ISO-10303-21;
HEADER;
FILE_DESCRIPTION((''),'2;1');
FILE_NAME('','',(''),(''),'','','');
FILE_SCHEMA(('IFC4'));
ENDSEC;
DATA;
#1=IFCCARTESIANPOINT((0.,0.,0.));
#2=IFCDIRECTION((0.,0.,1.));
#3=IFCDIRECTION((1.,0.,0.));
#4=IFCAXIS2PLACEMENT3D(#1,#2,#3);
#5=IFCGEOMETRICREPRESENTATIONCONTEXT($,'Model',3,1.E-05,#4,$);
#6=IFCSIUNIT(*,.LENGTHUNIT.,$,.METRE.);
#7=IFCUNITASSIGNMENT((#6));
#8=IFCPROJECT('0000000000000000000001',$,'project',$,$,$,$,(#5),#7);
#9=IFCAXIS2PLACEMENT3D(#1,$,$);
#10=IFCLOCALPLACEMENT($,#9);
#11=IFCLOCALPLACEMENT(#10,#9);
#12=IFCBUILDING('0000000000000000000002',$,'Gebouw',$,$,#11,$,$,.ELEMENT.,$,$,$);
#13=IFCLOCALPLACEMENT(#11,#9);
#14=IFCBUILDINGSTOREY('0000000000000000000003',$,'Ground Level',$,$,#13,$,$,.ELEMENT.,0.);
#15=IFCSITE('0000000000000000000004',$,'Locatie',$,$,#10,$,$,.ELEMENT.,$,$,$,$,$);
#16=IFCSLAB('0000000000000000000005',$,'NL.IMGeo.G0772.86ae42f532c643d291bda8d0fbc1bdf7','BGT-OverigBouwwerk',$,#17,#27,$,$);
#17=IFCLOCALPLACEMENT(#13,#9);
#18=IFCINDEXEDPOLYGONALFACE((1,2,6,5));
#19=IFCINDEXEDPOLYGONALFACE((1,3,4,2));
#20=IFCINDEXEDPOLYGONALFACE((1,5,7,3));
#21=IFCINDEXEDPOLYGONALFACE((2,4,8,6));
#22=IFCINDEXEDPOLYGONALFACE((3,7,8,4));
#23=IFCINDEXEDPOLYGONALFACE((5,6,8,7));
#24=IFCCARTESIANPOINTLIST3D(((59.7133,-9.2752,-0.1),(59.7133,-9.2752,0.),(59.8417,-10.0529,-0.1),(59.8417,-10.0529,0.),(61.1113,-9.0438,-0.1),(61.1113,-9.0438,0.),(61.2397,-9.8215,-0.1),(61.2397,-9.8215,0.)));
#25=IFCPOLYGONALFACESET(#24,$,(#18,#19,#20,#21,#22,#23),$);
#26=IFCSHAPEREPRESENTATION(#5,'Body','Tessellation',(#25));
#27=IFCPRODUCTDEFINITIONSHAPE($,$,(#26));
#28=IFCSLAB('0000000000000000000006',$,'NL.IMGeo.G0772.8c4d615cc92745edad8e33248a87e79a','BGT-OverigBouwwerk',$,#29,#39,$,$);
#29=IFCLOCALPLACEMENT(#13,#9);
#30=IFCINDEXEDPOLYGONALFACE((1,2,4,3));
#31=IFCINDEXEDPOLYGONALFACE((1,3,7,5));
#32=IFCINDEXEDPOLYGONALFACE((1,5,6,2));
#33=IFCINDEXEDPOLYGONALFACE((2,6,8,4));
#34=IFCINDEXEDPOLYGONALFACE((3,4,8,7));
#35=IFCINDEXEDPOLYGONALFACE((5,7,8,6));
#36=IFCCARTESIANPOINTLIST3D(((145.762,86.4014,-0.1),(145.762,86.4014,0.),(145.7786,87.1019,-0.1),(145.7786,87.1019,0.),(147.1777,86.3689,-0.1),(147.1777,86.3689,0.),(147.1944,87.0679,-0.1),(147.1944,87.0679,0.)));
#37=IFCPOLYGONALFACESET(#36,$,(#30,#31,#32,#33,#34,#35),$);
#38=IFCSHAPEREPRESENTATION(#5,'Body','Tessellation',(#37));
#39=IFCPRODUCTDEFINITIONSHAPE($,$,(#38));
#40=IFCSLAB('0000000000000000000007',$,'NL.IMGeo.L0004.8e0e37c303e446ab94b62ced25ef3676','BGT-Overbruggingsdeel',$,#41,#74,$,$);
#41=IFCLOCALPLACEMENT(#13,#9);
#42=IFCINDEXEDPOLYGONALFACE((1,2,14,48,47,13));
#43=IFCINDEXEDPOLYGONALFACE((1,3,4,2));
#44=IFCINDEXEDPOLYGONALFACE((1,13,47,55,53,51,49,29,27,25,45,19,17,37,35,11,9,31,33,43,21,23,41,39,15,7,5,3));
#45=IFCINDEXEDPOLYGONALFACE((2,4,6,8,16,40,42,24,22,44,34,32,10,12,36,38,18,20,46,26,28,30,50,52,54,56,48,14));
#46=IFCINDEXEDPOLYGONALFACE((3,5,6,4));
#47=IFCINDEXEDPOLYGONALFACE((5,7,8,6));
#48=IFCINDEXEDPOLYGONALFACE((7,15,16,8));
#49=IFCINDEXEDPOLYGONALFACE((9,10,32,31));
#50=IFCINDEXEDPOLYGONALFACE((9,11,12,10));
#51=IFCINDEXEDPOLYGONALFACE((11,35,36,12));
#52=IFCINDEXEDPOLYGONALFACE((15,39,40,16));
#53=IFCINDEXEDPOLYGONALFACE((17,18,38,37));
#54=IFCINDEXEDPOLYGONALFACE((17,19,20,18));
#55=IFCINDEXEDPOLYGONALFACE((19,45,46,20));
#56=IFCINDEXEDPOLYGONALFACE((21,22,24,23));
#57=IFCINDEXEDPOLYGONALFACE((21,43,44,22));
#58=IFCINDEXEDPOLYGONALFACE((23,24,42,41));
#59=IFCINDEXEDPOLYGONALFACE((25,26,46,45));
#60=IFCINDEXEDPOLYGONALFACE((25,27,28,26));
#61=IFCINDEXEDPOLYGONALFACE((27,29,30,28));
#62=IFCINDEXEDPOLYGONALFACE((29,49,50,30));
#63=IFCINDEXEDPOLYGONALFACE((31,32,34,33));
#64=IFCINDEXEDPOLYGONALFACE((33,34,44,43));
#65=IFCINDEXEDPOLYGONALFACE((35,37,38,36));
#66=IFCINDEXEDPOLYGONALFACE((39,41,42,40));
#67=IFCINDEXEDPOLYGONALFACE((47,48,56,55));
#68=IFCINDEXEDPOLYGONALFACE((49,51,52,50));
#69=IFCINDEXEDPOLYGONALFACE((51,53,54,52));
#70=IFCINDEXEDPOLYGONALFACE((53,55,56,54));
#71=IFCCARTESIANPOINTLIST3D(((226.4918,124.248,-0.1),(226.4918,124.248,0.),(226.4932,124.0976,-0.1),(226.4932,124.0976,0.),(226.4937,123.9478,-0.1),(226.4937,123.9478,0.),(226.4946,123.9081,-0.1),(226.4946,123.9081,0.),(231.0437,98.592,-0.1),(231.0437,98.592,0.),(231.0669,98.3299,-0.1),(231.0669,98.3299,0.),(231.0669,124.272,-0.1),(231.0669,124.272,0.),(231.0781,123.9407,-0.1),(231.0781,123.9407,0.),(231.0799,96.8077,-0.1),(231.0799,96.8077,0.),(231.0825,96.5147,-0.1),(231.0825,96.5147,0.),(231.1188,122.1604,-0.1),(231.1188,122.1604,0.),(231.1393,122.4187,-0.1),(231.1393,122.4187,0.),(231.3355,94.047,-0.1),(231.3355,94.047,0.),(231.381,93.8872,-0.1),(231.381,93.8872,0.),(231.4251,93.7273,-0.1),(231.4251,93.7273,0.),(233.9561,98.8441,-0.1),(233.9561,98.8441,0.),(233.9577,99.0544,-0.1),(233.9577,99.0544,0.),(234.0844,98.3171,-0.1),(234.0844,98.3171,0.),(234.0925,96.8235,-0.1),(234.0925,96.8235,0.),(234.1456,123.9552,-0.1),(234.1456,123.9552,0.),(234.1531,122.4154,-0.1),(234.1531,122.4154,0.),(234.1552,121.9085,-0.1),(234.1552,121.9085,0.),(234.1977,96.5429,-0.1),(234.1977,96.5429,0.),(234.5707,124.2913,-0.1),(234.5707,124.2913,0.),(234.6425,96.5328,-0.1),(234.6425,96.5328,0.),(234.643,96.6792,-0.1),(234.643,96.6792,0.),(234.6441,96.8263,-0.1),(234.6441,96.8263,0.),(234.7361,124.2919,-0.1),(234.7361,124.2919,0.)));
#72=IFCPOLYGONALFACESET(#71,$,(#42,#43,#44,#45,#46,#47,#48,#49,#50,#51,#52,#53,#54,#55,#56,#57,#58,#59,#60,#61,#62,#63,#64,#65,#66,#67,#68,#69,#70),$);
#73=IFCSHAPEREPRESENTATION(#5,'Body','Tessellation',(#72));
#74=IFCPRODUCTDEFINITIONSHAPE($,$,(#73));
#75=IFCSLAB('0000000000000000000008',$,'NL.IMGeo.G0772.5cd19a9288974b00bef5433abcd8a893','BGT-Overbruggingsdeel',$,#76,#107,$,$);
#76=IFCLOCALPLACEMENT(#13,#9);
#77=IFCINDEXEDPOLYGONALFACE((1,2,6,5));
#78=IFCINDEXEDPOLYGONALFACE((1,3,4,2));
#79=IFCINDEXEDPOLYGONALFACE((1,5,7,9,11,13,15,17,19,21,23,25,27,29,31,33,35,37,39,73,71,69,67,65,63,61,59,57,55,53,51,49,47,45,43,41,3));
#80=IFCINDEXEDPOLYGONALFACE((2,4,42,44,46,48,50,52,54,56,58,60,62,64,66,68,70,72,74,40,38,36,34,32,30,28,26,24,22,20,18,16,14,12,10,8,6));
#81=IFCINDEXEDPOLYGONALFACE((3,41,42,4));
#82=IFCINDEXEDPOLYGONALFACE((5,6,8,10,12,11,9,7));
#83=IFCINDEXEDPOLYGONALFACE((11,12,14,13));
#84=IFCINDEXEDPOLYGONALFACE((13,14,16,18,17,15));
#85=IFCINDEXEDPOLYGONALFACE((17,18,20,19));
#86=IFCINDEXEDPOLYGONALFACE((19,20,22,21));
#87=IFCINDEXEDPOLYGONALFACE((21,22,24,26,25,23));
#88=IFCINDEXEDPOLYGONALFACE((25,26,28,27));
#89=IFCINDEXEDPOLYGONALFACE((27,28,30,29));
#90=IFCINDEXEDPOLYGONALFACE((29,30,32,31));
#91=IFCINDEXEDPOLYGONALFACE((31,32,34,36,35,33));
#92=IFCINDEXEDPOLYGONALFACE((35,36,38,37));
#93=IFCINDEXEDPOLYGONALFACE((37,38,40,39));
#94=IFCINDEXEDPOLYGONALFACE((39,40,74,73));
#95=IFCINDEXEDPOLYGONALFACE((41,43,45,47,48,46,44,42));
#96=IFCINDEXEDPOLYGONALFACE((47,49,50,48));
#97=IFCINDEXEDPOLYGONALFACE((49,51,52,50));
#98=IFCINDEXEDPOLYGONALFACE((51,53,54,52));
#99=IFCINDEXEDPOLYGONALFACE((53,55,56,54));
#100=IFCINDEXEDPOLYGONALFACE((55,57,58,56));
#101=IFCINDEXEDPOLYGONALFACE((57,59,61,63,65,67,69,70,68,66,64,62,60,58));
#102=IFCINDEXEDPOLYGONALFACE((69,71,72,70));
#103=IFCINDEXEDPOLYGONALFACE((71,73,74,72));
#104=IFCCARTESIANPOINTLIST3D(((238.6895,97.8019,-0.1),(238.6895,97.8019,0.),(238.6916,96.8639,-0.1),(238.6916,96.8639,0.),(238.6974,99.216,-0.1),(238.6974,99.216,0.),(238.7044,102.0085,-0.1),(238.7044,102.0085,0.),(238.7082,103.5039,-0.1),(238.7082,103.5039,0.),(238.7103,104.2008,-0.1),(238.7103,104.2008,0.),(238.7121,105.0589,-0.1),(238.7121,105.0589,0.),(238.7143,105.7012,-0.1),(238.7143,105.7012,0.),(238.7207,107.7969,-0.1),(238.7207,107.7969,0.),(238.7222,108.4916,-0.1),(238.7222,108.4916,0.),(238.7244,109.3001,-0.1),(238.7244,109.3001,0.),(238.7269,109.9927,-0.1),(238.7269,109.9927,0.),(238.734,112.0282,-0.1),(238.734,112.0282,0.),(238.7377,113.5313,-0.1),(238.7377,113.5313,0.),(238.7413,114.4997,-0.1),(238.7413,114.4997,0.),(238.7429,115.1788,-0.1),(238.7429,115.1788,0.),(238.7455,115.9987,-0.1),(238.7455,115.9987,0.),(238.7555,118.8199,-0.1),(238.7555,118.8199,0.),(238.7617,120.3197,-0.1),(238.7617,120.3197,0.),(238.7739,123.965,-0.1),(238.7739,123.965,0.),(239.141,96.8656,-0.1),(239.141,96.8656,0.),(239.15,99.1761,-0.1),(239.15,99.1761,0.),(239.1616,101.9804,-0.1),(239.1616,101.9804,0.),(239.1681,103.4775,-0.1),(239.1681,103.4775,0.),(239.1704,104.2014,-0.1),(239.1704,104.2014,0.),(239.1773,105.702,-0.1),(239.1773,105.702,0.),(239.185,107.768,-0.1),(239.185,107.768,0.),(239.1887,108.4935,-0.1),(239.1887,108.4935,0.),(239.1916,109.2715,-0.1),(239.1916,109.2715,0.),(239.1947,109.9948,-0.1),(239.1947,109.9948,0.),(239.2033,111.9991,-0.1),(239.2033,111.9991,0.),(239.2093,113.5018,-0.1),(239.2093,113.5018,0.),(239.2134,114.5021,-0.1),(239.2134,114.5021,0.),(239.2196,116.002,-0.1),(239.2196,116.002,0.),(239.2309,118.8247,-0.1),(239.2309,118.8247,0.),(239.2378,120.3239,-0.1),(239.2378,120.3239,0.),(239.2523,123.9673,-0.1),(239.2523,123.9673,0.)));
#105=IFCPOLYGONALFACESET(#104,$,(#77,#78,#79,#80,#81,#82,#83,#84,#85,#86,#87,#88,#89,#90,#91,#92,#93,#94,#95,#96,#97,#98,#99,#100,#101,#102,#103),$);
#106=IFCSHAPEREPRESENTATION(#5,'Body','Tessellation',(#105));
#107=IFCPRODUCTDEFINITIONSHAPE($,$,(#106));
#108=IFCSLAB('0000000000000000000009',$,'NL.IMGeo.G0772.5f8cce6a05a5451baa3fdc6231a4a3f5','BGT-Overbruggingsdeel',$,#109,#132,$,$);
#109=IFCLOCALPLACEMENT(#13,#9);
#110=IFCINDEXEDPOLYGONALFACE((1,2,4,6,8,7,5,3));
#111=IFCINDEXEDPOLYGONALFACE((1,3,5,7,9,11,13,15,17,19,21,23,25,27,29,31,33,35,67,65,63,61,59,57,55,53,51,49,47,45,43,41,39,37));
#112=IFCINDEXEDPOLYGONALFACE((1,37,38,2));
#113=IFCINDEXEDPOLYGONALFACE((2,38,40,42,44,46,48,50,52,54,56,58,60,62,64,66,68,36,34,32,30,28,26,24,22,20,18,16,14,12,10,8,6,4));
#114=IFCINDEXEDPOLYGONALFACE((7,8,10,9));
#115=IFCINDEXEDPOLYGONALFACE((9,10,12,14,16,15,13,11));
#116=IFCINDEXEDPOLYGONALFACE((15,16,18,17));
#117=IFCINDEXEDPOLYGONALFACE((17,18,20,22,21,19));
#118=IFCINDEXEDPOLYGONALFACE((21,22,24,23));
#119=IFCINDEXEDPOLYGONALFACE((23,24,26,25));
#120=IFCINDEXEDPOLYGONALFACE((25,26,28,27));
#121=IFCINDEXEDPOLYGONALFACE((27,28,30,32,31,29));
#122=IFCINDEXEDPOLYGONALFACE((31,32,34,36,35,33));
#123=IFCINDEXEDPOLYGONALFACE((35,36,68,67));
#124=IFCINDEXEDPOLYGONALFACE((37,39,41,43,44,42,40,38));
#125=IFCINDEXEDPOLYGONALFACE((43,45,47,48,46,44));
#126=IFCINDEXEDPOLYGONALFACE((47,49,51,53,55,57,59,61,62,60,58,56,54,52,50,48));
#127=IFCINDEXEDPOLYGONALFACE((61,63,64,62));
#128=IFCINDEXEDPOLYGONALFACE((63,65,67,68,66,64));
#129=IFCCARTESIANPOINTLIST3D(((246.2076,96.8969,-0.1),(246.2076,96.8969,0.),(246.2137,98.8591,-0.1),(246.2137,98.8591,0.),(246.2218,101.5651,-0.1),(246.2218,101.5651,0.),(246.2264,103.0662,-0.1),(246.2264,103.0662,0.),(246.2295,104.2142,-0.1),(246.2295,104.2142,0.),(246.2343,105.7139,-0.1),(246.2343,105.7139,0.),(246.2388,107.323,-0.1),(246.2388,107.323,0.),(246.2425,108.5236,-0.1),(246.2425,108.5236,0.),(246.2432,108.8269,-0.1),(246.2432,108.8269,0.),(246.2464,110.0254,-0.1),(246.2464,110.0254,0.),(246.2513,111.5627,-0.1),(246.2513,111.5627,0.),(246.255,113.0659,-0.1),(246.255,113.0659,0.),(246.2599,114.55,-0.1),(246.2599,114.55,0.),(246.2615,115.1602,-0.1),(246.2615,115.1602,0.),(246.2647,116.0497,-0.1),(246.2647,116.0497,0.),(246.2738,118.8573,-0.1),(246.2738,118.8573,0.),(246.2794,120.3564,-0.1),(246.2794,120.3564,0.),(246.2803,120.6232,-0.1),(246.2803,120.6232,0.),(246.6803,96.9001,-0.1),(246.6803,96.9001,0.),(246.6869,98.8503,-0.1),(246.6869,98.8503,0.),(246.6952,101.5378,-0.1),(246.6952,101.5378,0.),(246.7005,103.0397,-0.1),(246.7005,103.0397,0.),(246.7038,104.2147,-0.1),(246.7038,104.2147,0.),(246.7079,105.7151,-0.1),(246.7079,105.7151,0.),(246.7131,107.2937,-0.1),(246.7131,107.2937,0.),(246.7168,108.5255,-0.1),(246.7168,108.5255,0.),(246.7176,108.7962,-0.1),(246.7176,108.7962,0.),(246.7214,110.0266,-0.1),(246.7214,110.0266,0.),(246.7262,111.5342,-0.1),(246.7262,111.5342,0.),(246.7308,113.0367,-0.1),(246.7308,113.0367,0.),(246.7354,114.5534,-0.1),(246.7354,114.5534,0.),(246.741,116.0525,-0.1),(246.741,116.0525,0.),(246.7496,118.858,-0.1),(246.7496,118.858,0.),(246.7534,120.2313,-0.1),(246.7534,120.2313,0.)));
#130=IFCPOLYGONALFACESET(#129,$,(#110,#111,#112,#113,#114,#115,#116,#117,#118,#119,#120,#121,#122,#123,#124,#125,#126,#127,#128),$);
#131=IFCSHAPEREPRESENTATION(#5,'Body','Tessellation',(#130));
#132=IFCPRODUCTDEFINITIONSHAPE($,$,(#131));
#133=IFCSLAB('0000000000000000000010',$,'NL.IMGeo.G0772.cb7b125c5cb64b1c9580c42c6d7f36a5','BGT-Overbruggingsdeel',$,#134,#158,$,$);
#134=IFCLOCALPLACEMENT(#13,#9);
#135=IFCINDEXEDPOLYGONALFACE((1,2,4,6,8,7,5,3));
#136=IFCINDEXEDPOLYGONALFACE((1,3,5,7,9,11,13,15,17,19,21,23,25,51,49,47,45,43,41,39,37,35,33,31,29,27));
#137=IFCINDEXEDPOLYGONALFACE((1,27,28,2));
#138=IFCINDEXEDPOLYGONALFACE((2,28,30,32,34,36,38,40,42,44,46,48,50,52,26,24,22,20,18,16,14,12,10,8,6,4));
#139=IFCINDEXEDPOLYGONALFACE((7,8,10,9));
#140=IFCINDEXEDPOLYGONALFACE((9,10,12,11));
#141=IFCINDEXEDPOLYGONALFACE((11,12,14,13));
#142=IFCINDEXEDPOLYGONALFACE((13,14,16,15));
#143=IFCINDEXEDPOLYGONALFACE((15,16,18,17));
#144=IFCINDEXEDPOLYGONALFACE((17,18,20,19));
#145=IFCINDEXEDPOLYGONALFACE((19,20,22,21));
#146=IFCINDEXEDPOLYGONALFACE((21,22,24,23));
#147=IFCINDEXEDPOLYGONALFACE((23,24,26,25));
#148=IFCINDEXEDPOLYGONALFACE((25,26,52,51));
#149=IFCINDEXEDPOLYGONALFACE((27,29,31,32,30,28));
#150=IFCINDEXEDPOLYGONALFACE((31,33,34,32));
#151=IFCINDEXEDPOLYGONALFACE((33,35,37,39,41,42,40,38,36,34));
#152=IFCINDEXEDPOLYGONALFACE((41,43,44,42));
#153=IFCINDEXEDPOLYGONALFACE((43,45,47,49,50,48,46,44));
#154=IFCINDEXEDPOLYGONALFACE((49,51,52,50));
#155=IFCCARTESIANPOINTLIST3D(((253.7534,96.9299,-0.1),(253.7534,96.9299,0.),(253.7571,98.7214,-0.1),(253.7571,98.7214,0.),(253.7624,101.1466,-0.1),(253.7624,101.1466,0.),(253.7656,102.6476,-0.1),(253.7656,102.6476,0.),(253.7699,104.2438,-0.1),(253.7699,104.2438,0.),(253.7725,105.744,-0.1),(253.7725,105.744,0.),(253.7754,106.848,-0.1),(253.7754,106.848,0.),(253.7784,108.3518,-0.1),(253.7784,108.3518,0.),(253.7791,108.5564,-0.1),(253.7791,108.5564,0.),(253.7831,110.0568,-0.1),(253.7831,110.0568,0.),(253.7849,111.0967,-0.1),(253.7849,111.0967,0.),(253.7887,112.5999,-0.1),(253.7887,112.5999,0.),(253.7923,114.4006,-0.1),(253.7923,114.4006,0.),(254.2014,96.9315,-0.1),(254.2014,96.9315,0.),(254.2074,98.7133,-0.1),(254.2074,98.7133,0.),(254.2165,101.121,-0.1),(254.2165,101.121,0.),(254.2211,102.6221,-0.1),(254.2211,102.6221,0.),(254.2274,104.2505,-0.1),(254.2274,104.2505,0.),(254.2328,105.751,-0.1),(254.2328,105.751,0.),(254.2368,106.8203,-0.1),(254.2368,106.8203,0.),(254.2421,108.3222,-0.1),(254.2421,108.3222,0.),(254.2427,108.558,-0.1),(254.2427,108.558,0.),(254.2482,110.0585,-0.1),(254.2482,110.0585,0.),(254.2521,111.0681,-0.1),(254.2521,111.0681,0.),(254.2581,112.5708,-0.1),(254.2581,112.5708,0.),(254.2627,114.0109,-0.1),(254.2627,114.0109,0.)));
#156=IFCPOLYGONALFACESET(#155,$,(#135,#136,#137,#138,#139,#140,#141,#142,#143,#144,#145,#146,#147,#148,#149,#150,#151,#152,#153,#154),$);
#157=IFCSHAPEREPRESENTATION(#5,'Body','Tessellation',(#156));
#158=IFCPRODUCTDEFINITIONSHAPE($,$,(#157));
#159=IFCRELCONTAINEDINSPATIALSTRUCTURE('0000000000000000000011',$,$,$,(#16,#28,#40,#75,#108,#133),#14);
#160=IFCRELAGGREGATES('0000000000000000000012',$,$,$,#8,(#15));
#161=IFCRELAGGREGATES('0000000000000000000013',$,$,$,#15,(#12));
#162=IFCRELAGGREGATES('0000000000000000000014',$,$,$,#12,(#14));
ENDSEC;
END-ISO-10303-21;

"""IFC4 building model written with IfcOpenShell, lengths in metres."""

from ifc_helpers import new_model, si_unit, frame, origin, origin_with_axes, place, context, project, spatial, polyline, outline, extrude, element, save


model = new_model("IFC4")

# Units and contexts
model_context = context("Model", 3, precision=1e-05, world=origin_with_axes())
ifc_project = project(units=[si_unit("LENGTHUNIT", "METRE")], contexts=[model_context])

# Site, building, storey
site_placement = place(None, origin())
site = spatial("IfcSite", under=ifc_project, at=site_placement, Name="Locatie", CompositionType="ELEMENT")
building_placement = place(site_placement, origin())
building = spatial("IfcBuilding", under=site, at=building_placement, Name="Gebouw", CompositionType="ELEMENT")
storey_placement = place(building_placement, origin())
storey = spatial("IfcBuildingStorey", under=building, at=storey_placement, Name="Ground Level", CompositionType="ELEMENT", Elevation=0.0)

# Slabs
slab_1_placement = place(storey_placement, origin())
element("IfcSlab", 1, at=slab_1_placement, inside=storey, Name="NL.IMGeo.G0772.86ae42f532c643d291bda8d0fbc1bdf7", Description="BGT-OverigBouwwerk", context=model_context, shape_type="SweptSolid", body=[
    extrude(outline(polyline([(59.8417, -10.0529), (59.7133, -9.2752), (61.1113, -9.0438), (61.2397, -9.8215), (59.8417, -10.0529)])), frame((0.0, 0.0, -0.1), z_axis=(0.0, 0.0, 1.0), x_axis=(1.0, 0.0, 0.0)), (0.0, 0.0, 1.0), 0.1),
])
slab_2_placement = place(storey_placement, origin())
element("IfcSlab", 2, at=slab_2_placement, inside=storey, Name="NL.IMGeo.G0772.8c4d615cc92745edad8e33248a87e79a", Description="BGT-OverigBouwwerk", context=model_context, shape_type="SweptSolid", body=[
    extrude(outline(polyline([(145.762, 86.4014), (145.7786, 87.1019), (147.1944, 87.0679), (147.1777, 86.3689), (145.762, 86.4014)])), frame((0.0, 0.0, -0.1), z_axis=(0.0, 0.0, 1.0), x_axis=(1.0, 0.0, 0.0)), (0.0, 0.0, 1.0), 0.1),
])
slab_3_placement = place(storey_placement, origin())
element("IfcSlab", 3, at=slab_3_placement, inside=storey, Name="NL.IMGeo.L0004.8e0e37c303e446ab94b62ced25ef3676", Description="BGT-Overbruggingsdeel", context=model_context, shape_type="SweptSolid", body=[
    extrude(outline(polyline([(234.1977, 96.5429), (231.0825, 96.5147), (231.0799, 96.8077), (234.0925, 96.8235), (234.0844, 98.3171), (231.0669, 98.3299), (231.0437, 98.592), (233.9561, 98.8441), (233.9577, 99.0544), (234.1552, 121.9085), (231.1188, 122.1604), (231.1393, 122.4187), (234.1531, 122.4154), (234.1456, 123.9552), (231.0781, 123.9407), (226.4946, 123.9081), (226.4937, 123.9478), (226.4932, 124.0976), (226.4918, 124.248), (231.0669, 124.272), (234.5707, 124.2913), (234.7361, 124.2919), (234.6441, 96.8263), (234.643, 96.6792), (234.6425, 96.5328), (231.4251, 93.7273), (231.381, 93.8872), (231.3355, 94.047), (234.1977, 96.5429)])), frame((0.0, 0.0, -0.1), z_axis=(0.0, 0.0, 1.0), x_axis=(1.0, 0.0, 0.0)), (0.0, 0.0, 1.0), 0.1),
])
slab_4_placement = place(storey_placement, origin())
element("IfcSlab", 4, at=slab_4_placement, inside=storey, Name="NL.IMGeo.G0772.5cd19a9288974b00bef5433abcd8a893", Description="BGT-Overbruggingsdeel", context=model_context, shape_type="SweptSolid", body=[
    extrude(outline(polyline([(239.1773, 105.702), (239.1704, 104.2014), (239.1681, 103.4775), (239.1616, 101.9804), (239.15, 99.1761), (239.141, 96.8656), (238.6916, 96.8639), (238.6895, 97.8019), (238.6974, 99.216), (238.7044, 102.0085), (238.7082, 103.5039), (238.7103, 104.2008), (238.7121, 105.0589), (238.7143, 105.7012), (238.7207, 107.7969), (238.7222, 108.4916), (238.7244, 109.3001), (238.7269, 109.9927), (238.734, 112.0282), (238.7377, 113.5313), (238.7413, 114.4997), (238.7429, 115.1788), (238.7455, 115.9987), (238.7555, 118.8199), (238.7617, 120.3197), (238.7739, 123.965), (239.2523, 123.9673), (239.2378, 120.3239), (239.2309, 118.8247), (239.2196, 116.002), (239.2134, 114.5021), (239.2093, 113.5018), (239.2033, 111.9991), (239.1947, 109.9948), (239.1916, 109.2715), (239.1887, 108.4935), (239.185, 107.768), (239.1773, 105.702)])), frame((0.0, 0.0, -0.1), z_axis=(0.0, 0.0, 1.0), x_axis=(1.0, 0.0, 0.0)), (0.0, 0.0, 1.0), 0.1),
])
slab_5_placement = place(storey_placement, origin())
element("IfcSlab", 5, at=slab_5_placement, inside=storey, Name="NL.IMGeo.G0772.5f8cce6a05a5451baa3fdc6231a4a3f5", Description="BGT-Overbruggingsdeel", context=model_context, shape_type="SweptSolid", body=[
    extrude(outline(polyline([(246.7496, 118.858), (246.741, 116.0525), (246.7354, 114.5534), (246.7308, 113.0367), (246.7262, 111.5342), (246.7214, 110.0266), (246.7176, 108.7962), (246.7168, 108.5255), (246.7131, 107.2937), (246.7079, 105.7151), (246.7038, 104.2147), (246.7005, 103.0397), (246.6952, 101.5378), (246.6869, 98.8503), (246.6803, 96.9001), (246.2076, 96.8969), (246.2137, 98.8591), (246.2218, 101.5651), (246.2264, 103.0662), (246.2295, 104.2142), (246.2343, 105.7139), (246.2388, 107.323), (246.2425, 108.5236), (246.2432, 108.8269), (246.2464, 110.0254), (246.2513, 111.5627), (246.255, 113.0659), (246.2599, 114.55), (246.2615, 115.1602), (246.2647, 116.0497), (246.2738, 118.8573), (246.2794, 120.3564), (246.2803, 120.6232), (246.7534, 120.2313), (246.7496, 118.858)])), frame((0.0, 0.0, -0.1), z_axis=(0.0, 0.0, 1.0), x_axis=(1.0, 0.0, 0.0)), (0.0, 0.0, 1.0), 0.1),
])
slab_6_placement = place(storey_placement, origin())
element("IfcSlab", 6, at=slab_6_placement, inside=storey, Name="NL.IMGeo.G0772.cb7b125c5cb64b1c9580c42c6d7f36a5", Description="BGT-Overbruggingsdeel", context=model_context, shape_type="SweptSolid", body=[
    extrude(outline(polyline([(254.2581, 112.5708), (254.2521, 111.0681), (254.2482, 110.0585), (254.2427, 108.558), (254.2421, 108.3222), (254.2368, 106.8203), (254.2328, 105.751), (254.2274, 104.2505), (254.2211, 102.6221), (254.2165, 101.121), (254.2074, 98.7133), (254.2014, 96.9315), (253.7534, 96.9299), (253.7571, 98.7214), (253.7624, 101.1466), (253.7656, 102.6476), (253.7699, 104.2438), (253.7725, 105.744), (253.7754, 106.848), (253.7784, 108.3518), (253.7791, 108.5564), (253.7831, 110.0568), (253.7849, 111.0967), (253.7887, 112.5999), (253.7923, 114.4006), (254.2627, 114.0109), (254.2581, 112.5708)])), frame((0.0, 0.0, -0.1), z_axis=(0.0, 0.0, 1.0), x_axis=(1.0, 0.0, 0.0)), (0.0, 0.0, 1.0), 0.1),
])

save(model, "model.ifc")
